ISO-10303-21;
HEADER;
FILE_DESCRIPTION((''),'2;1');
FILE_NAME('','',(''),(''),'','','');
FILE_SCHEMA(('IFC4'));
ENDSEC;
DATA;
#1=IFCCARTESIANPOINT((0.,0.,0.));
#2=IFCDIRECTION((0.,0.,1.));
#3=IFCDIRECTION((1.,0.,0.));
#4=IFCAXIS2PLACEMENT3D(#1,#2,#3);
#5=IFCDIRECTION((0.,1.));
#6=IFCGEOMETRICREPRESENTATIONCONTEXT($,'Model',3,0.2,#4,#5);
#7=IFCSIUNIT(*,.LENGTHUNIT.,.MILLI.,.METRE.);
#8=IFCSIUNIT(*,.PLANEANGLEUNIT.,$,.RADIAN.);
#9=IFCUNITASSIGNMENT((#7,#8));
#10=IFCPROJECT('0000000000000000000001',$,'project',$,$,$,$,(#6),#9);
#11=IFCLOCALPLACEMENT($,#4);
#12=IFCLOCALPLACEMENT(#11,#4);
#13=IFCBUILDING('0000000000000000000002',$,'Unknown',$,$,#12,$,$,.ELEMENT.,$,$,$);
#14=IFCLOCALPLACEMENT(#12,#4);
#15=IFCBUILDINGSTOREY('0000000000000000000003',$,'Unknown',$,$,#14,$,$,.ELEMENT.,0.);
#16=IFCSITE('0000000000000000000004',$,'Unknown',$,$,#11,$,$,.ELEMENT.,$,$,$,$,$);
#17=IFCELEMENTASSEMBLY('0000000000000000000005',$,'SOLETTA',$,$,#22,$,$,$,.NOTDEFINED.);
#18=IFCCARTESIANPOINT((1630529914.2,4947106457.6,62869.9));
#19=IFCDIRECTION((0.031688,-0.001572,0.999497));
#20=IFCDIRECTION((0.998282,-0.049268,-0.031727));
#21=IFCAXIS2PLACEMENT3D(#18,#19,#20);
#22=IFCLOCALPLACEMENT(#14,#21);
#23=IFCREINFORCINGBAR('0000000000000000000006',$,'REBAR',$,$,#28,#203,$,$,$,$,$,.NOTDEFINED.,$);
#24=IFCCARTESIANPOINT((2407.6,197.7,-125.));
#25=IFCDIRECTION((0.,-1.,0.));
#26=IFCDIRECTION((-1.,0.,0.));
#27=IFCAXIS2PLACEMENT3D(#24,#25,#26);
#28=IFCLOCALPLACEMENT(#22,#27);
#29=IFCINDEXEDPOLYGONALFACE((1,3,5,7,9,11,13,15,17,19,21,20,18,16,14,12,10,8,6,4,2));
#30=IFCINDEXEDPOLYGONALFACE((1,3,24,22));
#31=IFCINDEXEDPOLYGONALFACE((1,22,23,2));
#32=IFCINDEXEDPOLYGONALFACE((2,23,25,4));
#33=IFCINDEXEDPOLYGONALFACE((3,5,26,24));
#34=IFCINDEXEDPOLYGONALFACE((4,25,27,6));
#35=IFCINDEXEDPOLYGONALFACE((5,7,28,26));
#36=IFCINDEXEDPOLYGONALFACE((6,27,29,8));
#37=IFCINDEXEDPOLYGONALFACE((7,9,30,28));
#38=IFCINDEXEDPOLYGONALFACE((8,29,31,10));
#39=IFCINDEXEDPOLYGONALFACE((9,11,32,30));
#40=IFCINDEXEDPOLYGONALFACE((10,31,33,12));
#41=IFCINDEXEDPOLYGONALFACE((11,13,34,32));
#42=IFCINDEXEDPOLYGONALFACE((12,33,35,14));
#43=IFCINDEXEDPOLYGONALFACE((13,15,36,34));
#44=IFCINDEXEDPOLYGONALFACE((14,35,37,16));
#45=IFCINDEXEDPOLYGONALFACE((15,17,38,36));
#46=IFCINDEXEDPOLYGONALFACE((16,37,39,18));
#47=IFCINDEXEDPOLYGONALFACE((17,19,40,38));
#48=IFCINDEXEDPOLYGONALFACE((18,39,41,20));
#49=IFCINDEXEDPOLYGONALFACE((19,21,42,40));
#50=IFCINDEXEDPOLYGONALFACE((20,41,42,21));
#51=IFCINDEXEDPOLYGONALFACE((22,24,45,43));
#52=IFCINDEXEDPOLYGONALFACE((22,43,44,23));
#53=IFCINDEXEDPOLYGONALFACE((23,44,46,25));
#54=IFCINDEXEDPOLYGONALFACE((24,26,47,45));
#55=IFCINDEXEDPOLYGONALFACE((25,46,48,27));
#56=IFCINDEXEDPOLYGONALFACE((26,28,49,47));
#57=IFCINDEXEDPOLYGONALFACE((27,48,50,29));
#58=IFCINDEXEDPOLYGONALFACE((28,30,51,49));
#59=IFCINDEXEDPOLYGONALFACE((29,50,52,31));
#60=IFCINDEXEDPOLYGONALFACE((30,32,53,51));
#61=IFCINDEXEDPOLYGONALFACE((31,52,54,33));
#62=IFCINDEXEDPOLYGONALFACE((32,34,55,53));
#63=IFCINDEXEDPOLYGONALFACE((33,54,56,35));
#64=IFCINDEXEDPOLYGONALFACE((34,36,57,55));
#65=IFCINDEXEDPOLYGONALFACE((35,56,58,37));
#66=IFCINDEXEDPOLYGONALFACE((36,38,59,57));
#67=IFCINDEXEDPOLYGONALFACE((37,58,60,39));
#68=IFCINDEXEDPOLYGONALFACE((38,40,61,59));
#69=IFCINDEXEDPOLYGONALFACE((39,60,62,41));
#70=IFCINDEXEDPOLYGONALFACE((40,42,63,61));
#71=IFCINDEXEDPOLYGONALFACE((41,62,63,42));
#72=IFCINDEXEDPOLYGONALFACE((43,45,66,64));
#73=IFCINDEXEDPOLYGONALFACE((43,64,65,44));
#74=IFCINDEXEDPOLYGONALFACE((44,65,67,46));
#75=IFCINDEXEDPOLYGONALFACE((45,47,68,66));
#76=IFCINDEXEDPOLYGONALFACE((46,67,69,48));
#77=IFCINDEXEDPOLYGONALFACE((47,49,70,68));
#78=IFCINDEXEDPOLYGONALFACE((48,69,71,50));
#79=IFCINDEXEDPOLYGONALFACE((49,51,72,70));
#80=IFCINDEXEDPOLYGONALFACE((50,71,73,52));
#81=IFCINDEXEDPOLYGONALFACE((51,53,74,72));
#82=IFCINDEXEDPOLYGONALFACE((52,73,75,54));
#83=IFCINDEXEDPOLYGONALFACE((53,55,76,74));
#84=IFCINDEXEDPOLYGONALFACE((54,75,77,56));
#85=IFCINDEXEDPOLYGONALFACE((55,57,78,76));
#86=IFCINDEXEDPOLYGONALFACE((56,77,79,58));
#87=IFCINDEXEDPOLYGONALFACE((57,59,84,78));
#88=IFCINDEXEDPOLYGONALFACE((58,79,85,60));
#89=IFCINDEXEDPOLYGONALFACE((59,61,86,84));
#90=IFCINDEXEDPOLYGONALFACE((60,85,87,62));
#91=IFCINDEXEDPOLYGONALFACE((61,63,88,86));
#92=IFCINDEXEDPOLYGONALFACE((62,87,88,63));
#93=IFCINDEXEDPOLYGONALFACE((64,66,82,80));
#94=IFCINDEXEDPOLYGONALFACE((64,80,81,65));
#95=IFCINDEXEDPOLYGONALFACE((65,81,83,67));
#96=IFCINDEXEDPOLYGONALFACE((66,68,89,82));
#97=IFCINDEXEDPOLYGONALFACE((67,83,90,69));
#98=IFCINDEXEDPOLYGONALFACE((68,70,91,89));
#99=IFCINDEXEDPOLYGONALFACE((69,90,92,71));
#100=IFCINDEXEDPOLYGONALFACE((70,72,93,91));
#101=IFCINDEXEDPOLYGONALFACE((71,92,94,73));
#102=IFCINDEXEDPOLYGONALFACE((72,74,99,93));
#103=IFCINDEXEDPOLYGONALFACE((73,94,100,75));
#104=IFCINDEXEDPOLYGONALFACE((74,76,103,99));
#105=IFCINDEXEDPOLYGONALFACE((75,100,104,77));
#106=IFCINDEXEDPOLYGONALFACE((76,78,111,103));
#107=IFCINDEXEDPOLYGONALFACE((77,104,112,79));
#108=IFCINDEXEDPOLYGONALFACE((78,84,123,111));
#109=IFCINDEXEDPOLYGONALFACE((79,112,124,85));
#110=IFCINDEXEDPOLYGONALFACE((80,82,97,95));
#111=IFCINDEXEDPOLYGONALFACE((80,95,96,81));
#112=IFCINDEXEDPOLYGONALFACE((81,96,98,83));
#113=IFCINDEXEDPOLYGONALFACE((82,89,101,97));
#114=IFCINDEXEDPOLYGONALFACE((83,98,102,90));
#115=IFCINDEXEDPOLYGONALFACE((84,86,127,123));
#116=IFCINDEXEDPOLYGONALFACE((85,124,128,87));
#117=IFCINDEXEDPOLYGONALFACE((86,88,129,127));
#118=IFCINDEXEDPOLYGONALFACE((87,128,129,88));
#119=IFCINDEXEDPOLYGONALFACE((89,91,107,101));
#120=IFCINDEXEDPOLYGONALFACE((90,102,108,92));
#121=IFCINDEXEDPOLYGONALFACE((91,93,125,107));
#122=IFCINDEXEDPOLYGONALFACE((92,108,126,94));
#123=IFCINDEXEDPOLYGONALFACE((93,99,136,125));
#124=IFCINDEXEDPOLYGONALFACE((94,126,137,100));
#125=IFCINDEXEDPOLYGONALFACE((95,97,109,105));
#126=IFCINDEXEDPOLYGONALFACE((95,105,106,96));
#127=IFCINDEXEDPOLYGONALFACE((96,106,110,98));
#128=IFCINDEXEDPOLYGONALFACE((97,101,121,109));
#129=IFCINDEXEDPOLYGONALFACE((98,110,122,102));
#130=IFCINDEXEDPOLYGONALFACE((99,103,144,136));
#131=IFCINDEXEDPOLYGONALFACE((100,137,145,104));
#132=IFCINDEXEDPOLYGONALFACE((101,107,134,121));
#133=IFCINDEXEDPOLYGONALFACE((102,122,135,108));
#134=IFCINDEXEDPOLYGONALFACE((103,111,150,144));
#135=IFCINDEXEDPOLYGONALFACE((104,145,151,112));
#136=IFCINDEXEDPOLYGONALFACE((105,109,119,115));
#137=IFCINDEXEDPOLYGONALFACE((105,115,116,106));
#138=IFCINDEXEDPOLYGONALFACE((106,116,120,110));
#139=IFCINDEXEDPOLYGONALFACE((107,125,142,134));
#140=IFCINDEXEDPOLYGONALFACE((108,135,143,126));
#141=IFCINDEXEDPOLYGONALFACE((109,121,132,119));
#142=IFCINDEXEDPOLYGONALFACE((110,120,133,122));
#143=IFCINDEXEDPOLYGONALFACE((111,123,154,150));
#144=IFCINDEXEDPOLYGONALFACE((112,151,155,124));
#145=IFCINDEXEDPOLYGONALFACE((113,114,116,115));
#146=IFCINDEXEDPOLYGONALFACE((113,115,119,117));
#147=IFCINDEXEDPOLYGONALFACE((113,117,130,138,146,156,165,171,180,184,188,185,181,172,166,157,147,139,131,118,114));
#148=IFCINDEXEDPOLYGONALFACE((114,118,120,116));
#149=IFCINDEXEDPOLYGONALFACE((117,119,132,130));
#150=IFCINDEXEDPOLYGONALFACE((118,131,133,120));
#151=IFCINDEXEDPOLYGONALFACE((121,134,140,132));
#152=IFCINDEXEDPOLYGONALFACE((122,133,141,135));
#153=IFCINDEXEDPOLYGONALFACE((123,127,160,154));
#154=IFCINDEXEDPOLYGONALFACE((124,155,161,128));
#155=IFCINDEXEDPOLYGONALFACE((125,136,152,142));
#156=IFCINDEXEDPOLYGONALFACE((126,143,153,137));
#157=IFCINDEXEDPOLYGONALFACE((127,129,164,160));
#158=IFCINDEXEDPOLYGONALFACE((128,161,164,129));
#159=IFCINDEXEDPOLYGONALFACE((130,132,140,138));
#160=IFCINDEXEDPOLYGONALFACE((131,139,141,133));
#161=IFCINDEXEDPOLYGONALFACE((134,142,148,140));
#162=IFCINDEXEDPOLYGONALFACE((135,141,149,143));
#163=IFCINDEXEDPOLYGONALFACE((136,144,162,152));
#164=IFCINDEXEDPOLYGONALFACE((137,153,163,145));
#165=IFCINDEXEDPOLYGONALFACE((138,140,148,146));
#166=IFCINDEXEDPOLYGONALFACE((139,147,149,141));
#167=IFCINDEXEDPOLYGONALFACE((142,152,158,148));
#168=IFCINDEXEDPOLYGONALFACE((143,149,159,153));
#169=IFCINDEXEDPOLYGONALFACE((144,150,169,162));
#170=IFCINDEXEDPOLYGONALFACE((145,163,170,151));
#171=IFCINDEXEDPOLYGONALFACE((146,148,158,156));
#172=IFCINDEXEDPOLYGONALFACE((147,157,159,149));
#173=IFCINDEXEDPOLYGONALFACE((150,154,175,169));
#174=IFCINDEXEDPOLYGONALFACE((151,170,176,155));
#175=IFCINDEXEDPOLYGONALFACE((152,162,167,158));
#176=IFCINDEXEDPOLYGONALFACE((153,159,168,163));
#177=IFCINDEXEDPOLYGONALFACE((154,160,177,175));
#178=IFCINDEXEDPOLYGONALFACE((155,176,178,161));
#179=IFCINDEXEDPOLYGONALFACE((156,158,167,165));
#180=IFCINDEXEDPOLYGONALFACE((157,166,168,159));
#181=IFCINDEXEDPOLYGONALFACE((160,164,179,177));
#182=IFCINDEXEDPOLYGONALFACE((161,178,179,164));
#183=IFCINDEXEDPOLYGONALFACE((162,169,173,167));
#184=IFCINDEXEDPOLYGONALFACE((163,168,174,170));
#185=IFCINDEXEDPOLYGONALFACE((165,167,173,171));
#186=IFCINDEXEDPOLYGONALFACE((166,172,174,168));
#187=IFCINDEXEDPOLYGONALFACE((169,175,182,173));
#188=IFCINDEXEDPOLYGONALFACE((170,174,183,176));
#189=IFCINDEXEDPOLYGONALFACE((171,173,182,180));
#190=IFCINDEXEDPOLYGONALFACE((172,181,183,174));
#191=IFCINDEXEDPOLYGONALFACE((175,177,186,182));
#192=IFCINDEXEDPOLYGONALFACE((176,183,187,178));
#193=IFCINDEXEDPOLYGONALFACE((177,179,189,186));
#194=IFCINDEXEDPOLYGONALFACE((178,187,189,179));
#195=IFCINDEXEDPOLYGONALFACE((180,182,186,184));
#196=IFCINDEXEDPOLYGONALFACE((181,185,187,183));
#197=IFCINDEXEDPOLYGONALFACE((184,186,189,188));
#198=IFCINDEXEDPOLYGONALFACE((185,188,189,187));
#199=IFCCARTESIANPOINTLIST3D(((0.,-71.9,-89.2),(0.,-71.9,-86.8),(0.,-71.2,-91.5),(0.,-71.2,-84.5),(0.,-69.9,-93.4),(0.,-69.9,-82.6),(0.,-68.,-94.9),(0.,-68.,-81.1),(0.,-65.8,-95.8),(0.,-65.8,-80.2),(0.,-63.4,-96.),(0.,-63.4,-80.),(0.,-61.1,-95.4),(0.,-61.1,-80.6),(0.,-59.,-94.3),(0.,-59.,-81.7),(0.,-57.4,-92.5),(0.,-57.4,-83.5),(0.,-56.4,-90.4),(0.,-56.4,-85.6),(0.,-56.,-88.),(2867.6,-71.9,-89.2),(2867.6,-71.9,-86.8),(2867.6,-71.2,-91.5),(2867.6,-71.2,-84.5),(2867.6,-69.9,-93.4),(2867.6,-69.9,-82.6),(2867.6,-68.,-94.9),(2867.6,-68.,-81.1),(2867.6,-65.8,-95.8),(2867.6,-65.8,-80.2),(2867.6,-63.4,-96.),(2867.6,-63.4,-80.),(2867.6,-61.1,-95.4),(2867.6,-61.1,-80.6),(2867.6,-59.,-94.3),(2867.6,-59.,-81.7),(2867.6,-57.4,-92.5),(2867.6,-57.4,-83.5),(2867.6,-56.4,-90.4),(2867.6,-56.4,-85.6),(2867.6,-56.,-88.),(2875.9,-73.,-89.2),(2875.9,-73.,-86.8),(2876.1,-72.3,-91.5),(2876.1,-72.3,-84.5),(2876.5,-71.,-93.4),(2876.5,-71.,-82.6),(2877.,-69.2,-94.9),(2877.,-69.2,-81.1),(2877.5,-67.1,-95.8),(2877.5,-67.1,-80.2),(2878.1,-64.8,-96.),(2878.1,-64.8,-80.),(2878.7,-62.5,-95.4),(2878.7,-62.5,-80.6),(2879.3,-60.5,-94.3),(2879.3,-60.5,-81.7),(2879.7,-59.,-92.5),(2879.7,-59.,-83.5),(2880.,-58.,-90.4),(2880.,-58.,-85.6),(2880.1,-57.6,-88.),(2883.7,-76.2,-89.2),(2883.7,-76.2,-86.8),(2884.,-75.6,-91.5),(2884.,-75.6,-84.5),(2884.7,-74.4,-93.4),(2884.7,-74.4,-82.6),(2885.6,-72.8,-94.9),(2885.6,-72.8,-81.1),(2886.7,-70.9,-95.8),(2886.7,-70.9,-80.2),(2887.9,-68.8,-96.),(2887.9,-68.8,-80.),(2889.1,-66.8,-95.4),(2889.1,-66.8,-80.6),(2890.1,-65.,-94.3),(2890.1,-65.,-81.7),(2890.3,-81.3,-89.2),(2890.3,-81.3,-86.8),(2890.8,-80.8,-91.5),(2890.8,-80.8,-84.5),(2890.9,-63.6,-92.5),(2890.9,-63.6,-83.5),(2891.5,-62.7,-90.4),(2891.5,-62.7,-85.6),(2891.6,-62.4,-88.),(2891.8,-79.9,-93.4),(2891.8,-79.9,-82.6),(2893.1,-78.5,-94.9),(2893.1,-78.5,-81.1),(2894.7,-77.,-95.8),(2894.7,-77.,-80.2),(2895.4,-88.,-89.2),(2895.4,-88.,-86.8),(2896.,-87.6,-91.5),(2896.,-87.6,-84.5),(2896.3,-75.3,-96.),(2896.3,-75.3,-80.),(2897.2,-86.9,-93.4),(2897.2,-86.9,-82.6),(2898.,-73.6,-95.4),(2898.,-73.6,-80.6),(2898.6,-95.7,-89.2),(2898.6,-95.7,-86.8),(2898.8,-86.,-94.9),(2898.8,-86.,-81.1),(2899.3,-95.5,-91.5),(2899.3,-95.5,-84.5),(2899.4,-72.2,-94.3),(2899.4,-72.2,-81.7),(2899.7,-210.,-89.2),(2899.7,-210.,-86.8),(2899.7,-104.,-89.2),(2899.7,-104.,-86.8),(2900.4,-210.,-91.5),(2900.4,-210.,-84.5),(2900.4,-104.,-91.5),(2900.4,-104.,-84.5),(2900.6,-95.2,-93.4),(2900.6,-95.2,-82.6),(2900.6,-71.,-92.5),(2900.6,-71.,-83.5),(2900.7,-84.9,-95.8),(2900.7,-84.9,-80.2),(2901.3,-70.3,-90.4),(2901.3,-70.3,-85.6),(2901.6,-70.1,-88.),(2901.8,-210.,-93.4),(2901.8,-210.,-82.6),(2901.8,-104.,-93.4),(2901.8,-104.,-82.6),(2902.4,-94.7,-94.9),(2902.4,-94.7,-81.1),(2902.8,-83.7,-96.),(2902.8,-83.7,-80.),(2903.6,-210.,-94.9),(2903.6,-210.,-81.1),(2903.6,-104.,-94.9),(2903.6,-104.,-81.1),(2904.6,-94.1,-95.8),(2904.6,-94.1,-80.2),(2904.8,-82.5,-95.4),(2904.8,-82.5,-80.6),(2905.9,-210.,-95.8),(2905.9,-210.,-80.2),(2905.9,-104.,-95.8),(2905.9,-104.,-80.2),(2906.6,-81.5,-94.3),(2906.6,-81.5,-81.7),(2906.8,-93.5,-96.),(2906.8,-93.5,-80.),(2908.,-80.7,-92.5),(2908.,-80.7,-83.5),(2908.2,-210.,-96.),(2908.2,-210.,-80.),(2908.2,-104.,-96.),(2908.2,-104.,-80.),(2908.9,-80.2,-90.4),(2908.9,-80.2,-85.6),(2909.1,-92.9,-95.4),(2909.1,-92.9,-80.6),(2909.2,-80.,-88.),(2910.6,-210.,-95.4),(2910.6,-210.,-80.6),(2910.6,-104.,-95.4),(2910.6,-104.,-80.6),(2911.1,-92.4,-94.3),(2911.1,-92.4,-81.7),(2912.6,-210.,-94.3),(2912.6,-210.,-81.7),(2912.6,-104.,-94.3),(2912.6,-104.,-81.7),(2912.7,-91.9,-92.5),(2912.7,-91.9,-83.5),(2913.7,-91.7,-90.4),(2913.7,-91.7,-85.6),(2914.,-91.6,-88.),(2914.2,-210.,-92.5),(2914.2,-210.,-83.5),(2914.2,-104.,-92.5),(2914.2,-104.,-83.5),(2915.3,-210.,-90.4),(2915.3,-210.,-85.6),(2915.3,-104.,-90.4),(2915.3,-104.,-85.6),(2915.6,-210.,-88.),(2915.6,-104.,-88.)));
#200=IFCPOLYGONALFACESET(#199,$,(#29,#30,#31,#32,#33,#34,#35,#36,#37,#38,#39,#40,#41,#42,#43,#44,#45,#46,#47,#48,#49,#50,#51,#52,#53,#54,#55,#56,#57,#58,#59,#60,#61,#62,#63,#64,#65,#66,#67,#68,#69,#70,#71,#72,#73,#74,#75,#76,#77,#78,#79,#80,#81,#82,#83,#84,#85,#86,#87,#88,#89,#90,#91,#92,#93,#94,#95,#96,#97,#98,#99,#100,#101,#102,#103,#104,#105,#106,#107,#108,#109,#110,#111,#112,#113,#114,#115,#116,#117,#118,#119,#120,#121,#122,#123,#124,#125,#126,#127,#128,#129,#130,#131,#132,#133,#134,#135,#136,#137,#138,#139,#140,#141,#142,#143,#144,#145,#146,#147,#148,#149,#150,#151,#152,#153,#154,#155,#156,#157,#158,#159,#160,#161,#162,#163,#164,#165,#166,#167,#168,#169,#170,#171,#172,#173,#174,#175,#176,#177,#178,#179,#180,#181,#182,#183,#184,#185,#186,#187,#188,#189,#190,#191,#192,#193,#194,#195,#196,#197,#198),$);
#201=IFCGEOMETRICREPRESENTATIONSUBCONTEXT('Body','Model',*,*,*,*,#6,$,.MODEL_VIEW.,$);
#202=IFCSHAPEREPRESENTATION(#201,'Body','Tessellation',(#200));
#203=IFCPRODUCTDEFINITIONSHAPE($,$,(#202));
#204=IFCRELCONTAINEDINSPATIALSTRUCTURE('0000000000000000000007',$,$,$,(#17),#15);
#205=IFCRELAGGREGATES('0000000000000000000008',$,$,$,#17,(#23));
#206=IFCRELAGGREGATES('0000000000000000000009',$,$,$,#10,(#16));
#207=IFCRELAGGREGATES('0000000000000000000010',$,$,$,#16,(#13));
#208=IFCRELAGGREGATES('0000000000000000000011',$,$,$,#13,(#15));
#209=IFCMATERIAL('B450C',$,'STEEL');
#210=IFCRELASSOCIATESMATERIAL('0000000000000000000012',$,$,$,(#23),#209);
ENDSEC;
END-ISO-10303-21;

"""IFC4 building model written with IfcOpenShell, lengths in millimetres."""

from ifc_helpers import new_model, entity, si_unit, direction, frame, origin_with_axes, place, context, subcontext, project, spatial, material, element, aggregate, save


model = new_model("IFC4")

# Units and contexts
model_context = context("Model", 3, precision=0.2, world=origin_with_axes(), true_north=direction((0.0, 1.0)))
body_context = subcontext(model_context, "Body", "Model", "MODEL_VIEW")
ifc_project = project(units=[si_unit("LENGTHUNIT", "METRE", prefix="MILLI"), si_unit("PLANEANGLEUNIT", "RADIAN")], contexts=[model_context])

# Site, building, storey
site_placement = place(None, origin_with_axes())
site = spatial("IfcSite", under=ifc_project, at=site_placement, Name="Unknown", CompositionType="ELEMENT")
building_placement = place(site_placement, origin_with_axes())
building = spatial("IfcBuilding", under=site, at=building_placement, Name="Unknown", CompositionType="ELEMENT")
storey_placement = place(building_placement, origin_with_axes())
storey = spatial("IfcBuildingStorey", under=building, at=storey_placement, Name="Unknown", CompositionType="ELEMENT", Elevation=0.0)

# Element assembly
ifc_material = material(Name="B450C", Category="STEEL")
assembly_1_placement = place(storey_placement, frame((1630529914.2, 4947106457.6, 62869.9), z_axis=(0.031688, -0.001572, 0.999497), x_axis=(0.998282, -0.049268, -0.031727)))
assembly_1 = element("IfcElementAssembly", 1, at=assembly_1_placement, inside=storey, Name="SOLETTA", PredefinedType="NOTDEFINED")

# Reinforcing bar
reinforcing_bar_1_placement = place(assembly_1_placement, frame((2407.6, 197.7, -125.0), z_axis=(0.0, -1.0, 0.0), x_axis=(-1.0, 0.0, 0.0)))
reinforcing_bar_1 = element("IfcReinforcingBar", 2, at=reinforcing_bar_1_placement, material=ifc_material, Name="REBAR", PredefinedType="NOTDEFINED", context=body_context, shape_type="AdvancedSweptSolid", body=[
    entity("IfcSweptDiskSolid", entity("IfcIndexedPolyCurve", entity("IfcCartesianPointList3D", [[0.0, -64.0, -88.0], [2867.6, -64.0, -88.0], [2895.9, -75.7, -88.0], [2907.6, -104.0, -88.0], [2907.6, -210.0, -88.0]]), [entity("IfcLineIndex", [1, 2]), entity("IfcArcIndex", [2, 3, 4]), entity("IfcLineIndex", [4, 5])]), 8.0),
])
aggregate(assembly_1, [reinforcing_bar_1])

save(model, "model.ifc")
